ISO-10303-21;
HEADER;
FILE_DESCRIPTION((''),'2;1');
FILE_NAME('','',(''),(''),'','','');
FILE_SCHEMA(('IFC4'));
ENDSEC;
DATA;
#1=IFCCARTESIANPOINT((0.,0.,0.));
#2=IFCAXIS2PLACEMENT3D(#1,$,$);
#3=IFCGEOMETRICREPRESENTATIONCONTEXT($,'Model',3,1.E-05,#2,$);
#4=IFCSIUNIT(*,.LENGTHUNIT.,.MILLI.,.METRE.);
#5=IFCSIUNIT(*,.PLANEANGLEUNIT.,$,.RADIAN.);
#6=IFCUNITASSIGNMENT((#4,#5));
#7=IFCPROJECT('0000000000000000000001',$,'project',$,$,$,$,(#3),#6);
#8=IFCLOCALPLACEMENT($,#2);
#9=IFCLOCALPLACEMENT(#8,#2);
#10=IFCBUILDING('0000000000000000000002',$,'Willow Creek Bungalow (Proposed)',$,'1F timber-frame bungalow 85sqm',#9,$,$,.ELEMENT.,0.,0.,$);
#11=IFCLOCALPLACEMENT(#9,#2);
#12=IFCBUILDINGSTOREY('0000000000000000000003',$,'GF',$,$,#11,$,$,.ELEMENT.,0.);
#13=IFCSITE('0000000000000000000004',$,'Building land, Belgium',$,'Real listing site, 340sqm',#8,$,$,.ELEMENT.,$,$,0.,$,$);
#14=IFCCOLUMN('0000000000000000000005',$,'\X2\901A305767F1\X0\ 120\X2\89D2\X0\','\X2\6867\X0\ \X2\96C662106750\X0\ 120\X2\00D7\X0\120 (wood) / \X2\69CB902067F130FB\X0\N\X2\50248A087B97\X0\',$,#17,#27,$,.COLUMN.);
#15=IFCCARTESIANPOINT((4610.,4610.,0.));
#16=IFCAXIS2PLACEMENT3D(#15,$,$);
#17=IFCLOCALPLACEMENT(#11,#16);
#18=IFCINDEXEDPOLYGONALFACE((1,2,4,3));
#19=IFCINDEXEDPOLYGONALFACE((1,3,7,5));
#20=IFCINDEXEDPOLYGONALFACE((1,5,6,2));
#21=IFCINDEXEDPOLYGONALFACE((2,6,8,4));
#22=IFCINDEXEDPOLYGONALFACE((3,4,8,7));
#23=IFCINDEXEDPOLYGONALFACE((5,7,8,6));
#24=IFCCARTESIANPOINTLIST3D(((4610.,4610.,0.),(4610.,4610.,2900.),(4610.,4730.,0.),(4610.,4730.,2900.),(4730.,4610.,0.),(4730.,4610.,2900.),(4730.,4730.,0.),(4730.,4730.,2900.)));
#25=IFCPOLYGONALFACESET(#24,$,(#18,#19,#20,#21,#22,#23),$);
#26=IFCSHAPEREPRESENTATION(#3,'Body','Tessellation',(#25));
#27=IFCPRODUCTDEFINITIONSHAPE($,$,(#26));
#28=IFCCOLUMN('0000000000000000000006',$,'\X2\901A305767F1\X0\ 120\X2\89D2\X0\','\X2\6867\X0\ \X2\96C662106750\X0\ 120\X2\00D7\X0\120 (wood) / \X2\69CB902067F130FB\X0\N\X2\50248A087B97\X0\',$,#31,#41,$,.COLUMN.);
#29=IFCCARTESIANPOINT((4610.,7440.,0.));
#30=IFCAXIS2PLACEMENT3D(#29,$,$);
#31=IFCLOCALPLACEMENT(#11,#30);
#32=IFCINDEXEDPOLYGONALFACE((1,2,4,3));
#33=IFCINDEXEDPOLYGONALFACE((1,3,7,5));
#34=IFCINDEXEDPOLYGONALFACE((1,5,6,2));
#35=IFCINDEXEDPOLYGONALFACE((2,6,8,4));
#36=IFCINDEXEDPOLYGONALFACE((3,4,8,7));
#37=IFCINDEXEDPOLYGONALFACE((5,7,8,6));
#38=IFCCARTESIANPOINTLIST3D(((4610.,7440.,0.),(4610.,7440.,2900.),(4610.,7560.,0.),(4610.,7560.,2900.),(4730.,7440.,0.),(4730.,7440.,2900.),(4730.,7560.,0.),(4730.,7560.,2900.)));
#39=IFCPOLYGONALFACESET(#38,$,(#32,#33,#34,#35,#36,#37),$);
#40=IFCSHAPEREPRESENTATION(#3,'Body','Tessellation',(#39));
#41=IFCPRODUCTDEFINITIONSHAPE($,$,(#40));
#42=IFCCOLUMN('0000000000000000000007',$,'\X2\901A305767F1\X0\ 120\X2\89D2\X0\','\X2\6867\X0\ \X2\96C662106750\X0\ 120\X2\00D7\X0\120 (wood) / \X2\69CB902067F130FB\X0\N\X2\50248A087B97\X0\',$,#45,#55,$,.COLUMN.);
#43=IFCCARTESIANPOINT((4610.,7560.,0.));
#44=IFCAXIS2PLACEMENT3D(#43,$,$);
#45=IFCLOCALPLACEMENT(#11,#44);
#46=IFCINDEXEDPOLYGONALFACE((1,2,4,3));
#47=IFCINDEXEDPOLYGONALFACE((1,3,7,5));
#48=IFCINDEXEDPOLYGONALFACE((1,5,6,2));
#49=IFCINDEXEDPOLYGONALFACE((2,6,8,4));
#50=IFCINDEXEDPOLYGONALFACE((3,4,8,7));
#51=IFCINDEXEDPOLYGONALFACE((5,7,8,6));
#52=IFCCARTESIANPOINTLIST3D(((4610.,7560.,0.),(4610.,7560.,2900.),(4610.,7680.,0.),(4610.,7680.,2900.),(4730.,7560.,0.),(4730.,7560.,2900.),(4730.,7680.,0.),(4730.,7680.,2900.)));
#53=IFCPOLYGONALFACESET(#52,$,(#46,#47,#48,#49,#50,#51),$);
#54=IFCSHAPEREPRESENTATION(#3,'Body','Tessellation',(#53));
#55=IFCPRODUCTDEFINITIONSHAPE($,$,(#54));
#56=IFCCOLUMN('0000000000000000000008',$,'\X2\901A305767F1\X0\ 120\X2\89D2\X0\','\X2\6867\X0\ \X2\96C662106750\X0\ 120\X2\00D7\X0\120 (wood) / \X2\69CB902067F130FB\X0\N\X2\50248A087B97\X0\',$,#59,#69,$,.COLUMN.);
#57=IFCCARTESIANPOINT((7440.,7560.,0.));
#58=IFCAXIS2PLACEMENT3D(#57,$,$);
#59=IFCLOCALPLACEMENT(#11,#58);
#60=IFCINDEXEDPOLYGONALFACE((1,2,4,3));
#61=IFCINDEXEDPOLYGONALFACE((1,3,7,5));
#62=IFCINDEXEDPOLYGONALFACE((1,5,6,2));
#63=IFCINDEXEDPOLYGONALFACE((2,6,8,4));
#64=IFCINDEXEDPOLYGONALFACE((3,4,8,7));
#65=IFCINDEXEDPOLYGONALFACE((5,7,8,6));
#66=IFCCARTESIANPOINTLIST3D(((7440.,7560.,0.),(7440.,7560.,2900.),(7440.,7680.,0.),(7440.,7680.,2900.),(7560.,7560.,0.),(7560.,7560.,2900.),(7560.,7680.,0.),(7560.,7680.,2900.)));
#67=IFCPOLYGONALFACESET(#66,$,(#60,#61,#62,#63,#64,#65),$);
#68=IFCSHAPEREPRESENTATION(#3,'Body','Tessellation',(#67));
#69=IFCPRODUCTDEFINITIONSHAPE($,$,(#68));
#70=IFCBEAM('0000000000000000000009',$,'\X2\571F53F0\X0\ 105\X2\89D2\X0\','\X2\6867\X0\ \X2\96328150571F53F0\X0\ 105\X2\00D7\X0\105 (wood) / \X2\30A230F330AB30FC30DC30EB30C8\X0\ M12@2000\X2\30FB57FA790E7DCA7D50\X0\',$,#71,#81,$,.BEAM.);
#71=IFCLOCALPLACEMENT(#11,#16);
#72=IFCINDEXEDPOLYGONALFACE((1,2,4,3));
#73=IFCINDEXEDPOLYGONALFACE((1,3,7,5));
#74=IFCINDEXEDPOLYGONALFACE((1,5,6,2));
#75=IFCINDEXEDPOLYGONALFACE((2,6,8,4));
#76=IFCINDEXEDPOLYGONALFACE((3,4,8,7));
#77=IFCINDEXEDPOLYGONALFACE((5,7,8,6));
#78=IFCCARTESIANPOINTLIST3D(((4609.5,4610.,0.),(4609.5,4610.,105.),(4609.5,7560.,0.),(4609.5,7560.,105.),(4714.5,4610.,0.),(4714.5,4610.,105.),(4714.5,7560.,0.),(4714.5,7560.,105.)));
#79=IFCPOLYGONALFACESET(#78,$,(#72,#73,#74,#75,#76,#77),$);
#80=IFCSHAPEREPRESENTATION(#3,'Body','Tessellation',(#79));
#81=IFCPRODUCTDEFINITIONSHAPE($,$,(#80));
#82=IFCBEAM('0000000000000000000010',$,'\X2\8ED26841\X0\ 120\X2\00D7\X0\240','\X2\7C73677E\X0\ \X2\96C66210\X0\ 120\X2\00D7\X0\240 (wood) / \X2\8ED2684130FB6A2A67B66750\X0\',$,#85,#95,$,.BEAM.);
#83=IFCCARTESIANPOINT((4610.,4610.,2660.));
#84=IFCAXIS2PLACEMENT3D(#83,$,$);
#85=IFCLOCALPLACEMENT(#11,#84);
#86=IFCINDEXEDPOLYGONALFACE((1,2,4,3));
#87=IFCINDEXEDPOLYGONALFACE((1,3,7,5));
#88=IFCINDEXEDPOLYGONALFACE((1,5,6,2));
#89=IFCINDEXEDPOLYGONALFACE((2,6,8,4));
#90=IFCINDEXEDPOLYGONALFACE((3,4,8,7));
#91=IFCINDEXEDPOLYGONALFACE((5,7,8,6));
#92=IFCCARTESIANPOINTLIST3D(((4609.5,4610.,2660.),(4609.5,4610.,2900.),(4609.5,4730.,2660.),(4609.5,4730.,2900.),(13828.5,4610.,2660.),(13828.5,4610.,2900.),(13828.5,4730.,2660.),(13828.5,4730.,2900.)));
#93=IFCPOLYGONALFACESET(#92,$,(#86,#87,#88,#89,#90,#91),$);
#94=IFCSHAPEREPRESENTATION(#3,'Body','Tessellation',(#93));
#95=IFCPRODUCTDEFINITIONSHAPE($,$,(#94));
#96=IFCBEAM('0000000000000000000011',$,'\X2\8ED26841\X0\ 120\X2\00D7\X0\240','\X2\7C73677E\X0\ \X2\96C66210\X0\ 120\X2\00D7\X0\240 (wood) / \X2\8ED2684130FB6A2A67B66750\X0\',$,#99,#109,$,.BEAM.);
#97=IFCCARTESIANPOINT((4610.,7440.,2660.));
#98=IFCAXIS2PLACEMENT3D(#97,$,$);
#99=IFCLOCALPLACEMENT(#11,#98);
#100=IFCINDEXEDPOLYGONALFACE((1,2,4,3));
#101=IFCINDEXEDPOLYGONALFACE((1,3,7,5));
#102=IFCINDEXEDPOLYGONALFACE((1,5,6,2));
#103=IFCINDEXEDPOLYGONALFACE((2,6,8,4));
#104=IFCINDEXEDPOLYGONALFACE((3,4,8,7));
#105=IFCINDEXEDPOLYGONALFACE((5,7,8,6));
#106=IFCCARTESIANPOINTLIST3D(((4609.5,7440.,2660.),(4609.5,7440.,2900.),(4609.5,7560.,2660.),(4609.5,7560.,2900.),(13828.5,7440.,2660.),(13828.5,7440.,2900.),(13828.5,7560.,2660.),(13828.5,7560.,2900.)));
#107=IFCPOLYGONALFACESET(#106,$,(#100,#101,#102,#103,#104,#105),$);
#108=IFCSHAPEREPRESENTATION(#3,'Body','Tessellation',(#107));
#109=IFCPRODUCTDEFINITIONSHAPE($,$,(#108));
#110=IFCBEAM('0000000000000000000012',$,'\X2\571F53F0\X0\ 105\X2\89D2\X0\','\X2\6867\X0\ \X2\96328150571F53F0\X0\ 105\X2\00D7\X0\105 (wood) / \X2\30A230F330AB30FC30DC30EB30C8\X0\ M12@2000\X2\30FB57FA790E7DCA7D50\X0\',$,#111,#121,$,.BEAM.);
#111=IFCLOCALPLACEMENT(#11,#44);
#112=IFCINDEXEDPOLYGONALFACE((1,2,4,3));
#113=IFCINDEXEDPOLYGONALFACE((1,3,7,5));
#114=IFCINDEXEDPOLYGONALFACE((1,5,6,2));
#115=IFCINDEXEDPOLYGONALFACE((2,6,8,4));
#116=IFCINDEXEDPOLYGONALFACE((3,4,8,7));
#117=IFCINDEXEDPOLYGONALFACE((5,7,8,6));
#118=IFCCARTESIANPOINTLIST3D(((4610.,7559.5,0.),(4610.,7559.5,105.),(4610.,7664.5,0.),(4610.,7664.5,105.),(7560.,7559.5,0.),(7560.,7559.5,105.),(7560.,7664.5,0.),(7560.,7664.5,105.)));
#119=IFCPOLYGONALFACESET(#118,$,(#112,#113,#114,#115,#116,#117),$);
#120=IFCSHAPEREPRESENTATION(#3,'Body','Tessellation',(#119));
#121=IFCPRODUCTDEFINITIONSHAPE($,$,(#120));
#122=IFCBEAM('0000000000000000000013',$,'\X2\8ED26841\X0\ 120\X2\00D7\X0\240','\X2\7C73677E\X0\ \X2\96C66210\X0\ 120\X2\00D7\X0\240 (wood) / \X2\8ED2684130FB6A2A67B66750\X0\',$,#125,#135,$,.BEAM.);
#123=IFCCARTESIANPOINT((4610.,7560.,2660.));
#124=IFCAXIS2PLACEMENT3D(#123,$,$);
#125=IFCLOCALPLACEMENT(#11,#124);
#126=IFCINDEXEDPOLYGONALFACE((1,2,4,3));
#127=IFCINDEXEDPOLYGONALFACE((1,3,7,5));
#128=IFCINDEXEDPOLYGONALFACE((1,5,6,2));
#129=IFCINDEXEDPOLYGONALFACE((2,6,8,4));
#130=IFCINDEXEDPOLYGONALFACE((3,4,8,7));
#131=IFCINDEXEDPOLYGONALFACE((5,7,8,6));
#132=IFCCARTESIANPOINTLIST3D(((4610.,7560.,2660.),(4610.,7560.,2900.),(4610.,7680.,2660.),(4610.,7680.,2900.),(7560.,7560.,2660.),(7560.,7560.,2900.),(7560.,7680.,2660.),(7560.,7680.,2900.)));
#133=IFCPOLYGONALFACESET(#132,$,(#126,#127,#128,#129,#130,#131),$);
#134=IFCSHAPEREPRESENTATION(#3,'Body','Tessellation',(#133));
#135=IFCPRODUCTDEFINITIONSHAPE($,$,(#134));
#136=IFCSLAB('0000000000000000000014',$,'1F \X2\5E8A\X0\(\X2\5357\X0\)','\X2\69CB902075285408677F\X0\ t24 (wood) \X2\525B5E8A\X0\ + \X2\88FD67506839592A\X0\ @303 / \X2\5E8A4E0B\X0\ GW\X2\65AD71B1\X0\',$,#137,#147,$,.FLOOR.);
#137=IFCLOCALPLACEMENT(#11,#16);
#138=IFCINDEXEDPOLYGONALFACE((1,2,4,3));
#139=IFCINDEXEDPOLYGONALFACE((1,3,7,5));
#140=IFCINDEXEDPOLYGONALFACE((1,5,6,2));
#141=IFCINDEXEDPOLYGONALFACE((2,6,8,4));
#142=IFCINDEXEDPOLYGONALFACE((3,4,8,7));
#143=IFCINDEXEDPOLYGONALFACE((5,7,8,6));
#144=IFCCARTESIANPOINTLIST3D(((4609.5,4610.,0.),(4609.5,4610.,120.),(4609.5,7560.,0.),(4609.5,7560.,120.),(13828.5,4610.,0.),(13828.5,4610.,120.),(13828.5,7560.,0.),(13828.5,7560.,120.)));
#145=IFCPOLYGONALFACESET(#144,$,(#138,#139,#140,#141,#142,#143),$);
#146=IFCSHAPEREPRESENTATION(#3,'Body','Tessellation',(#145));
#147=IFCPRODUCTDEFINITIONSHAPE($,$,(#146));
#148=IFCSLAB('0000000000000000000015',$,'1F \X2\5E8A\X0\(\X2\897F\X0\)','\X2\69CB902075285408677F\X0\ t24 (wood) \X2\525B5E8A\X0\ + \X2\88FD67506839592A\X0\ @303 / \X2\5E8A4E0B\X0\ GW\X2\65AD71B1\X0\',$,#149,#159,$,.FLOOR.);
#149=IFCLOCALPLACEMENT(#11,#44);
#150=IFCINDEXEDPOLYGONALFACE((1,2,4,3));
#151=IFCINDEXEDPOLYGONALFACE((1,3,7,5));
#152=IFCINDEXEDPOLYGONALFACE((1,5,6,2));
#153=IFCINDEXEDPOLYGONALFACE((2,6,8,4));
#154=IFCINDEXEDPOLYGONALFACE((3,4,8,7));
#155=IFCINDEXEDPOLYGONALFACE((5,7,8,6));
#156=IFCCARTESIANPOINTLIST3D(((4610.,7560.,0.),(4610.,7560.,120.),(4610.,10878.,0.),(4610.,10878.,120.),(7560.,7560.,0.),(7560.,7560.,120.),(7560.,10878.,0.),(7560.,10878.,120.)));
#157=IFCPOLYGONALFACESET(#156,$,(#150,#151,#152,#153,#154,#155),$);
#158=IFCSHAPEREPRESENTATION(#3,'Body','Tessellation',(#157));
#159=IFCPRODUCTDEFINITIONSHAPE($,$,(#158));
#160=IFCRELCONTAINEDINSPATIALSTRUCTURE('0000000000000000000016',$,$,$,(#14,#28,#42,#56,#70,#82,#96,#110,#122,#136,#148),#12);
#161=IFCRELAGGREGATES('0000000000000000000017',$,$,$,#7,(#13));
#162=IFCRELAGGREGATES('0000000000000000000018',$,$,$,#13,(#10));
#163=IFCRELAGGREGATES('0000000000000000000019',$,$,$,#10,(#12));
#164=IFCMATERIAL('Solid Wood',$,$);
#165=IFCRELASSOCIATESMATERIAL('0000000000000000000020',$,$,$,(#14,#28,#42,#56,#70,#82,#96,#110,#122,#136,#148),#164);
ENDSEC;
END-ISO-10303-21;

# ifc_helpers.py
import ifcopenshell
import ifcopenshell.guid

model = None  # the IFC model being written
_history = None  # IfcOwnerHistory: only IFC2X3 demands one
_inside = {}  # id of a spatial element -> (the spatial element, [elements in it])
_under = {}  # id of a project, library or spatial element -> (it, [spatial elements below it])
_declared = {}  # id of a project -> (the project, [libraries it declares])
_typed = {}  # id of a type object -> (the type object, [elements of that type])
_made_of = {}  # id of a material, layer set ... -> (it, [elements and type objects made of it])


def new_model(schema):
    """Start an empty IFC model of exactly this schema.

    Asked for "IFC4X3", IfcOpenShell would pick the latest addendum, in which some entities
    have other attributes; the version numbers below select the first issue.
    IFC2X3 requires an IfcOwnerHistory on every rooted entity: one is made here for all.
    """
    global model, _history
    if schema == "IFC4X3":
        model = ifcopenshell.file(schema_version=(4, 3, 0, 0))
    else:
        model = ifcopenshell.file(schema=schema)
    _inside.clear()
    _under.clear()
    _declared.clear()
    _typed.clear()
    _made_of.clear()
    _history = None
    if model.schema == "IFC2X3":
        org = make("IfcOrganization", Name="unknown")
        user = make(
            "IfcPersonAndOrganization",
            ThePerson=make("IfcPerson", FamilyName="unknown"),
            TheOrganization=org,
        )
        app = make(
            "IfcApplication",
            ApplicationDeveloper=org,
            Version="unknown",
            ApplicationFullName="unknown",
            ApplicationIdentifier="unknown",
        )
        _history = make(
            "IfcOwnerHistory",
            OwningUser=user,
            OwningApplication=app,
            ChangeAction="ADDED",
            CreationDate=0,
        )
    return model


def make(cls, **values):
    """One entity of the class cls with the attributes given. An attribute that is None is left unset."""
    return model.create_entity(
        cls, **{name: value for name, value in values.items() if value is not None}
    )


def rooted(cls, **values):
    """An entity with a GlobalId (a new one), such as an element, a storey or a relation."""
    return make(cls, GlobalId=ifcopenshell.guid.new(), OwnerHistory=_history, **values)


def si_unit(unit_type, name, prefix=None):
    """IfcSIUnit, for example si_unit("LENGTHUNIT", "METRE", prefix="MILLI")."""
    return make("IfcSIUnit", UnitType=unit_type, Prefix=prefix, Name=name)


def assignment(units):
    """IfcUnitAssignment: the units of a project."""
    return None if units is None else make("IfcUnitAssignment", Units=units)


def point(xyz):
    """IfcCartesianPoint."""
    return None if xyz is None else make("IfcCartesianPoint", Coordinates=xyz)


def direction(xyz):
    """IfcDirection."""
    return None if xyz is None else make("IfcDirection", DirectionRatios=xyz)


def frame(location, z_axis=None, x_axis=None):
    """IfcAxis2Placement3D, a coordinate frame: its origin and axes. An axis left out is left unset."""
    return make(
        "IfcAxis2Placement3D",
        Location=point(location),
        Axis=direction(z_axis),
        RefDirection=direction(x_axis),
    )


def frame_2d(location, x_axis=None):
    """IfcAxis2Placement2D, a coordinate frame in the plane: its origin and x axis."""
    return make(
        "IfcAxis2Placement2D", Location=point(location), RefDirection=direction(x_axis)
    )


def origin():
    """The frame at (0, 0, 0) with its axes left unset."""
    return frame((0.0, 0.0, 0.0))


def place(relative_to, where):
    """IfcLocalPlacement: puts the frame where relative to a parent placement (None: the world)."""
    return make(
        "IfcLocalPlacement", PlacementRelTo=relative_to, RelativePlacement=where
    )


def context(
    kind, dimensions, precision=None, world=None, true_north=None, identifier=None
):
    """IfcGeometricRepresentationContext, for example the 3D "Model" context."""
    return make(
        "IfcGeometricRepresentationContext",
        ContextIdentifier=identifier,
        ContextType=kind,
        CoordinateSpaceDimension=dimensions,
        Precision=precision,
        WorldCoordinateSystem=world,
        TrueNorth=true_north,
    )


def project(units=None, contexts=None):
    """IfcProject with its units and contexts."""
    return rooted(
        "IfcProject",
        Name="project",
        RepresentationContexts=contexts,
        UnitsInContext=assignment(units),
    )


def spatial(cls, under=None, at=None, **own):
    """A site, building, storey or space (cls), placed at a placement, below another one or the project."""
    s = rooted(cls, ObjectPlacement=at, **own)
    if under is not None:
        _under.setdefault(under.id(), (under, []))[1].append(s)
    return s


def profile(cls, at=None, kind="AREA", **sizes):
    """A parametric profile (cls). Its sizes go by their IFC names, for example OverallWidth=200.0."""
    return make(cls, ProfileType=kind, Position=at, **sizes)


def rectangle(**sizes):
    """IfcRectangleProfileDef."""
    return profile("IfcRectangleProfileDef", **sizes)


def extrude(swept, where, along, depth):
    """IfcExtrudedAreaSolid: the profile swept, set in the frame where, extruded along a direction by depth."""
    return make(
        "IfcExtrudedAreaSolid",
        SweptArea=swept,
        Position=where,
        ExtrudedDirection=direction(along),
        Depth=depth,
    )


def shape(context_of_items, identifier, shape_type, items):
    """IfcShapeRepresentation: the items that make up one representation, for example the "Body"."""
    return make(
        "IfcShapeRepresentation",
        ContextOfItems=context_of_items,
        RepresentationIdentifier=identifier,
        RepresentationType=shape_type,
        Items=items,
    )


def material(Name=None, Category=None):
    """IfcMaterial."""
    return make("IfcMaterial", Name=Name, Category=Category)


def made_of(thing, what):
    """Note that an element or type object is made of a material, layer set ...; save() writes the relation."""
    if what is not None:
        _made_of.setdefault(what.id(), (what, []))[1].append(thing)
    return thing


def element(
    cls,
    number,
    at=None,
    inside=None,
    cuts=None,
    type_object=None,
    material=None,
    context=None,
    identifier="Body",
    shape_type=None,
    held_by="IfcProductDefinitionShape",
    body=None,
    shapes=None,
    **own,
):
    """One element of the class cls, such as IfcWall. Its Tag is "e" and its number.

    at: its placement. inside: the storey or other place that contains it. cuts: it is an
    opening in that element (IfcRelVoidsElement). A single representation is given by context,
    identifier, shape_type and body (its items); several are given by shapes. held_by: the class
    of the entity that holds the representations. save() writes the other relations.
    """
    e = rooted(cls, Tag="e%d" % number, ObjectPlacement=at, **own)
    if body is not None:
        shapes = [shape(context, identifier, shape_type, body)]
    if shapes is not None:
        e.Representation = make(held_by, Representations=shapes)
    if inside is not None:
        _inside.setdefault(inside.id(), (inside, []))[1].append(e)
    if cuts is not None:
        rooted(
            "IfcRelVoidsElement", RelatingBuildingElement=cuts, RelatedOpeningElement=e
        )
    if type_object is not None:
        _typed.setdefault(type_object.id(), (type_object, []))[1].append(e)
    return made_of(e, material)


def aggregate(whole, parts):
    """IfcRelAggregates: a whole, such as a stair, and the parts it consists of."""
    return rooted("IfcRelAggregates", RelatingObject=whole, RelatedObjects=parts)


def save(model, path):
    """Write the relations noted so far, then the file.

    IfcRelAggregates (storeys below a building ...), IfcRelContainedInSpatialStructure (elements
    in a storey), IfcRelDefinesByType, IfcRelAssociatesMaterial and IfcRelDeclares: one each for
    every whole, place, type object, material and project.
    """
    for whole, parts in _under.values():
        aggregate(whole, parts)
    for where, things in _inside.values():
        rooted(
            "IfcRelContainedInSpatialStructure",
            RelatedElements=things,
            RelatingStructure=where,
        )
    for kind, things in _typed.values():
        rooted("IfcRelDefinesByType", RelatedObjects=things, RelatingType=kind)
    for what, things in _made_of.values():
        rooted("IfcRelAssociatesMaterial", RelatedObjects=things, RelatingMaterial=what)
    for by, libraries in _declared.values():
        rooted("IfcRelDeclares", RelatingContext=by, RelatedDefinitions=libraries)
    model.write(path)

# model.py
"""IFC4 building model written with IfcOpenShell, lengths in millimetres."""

from ifc_helpers import new_model, si_unit, frame, frame_2d, origin, place, context, project, spatial, rectangle, extrude, material, element, save


model = new_model("IFC4")

# Units and contexts
model_context = context("Model", 3, precision=1e-05, world=origin())
ifc_project = project(units=[si_unit("LENGTHUNIT", "METRE", prefix="MILLI"), si_unit("PLANEANGLEUNIT", "RADIAN")], contexts=[model_context])

# Site, building, storey
site_placement = place(None, origin())
site = spatial("IfcSite", under=ifc_project, at=site_placement, Name="Building land, Belgium", ObjectType="Real listing site, 340sqm", CompositionType="ELEMENT", RefElevation=0.0)
building_placement = place(site_placement, origin())
building = spatial("IfcBuilding", under=site, at=building_placement, Name="Willow Creek Bungalow (Proposed)", ObjectType="1F timber-frame bungalow 85sqm", CompositionType="ELEMENT", ElevationOfRefHeight=0.0, ElevationOfTerrain=0.0)
storey_placement = place(building_placement, origin())
storey = spatial("IfcBuildingStorey", under=building, at=storey_placement, Name="GF", CompositionType="ELEMENT", Elevation=0.0)

# Columns
ifc_material_1 = material(Name="Solid Wood")
column_1_placement = place(storey_placement, frame((4610.0, 4610.0, 0.0)))
element("IfcColumn", 1, at=column_1_placement, inside=storey, material=ifc_material_1, Name="通し柱 120角", Description="桧 集成材 120×120 (wood) / 構造柱・N値計算", PredefinedType="COLUMN", context=model_context, shape_type="SweptSolid", body=[
    extrude(rectangle(XDim=120.0, YDim=120.0, at=frame_2d((60.0, 60.0))), frame((4610.0, 4610.0, 0.0)), (0.0, 0.0, 1.0), 2900.0),
])
column_2_placement = place(storey_placement, frame((4610.0, 7440.0, 0.0)))
element("IfcColumn", 2, at=column_2_placement, inside=storey, material=ifc_material_1, Name="通し柱 120角", Description="桧 集成材 120×120 (wood) / 構造柱・N値計算", PredefinedType="COLUMN", context=model_context, shape_type="SweptSolid", body=[
    extrude(rectangle(XDim=120.0, YDim=120.0, at=frame_2d((60.0, 60.0))), frame((4610.0, 7440.0, 0.0)), (0.0, 0.0, 1.0), 2900.0),
])
column_3_placement = place(storey_placement, frame((4610.0, 7560.0, 0.0)))
element("IfcColumn", 3, at=column_3_placement, inside=storey, material=ifc_material_1, Name="通し柱 120角", Description="桧 集成材 120×120 (wood) / 構造柱・N値計算", PredefinedType="COLUMN", context=model_context, shape_type="SweptSolid", body=[
    extrude(rectangle(XDim=120.0, YDim=120.0, at=frame_2d((60.0, 60.0))), frame((4610.0, 7560.0, 0.0)), (0.0, 0.0, 1.0), 2900.0),
])
column_4_placement = place(storey_placement, frame((7440.0, 7560.0, 0.0)))
element("IfcColumn", 4, at=column_4_placement, inside=storey, material=ifc_material_1, Name="通し柱 120角", Description="桧 集成材 120×120 (wood) / 構造柱・N値計算", PredefinedType="COLUMN", context=model_context, shape_type="SweptSolid", body=[
    extrude(rectangle(XDim=120.0, YDim=120.0, at=frame_2d((60.0, 60.0))), frame((7440.0, 7560.0, 0.0)), (0.0, 0.0, 1.0), 2900.0),
])

# Beams
beam_1_placement = place(storey_placement, frame((4610.0, 4610.0, 0.0)))
element("IfcBeam", 5, at=beam_1_placement, inside=storey, material=ifc_material_1, Name="土台 105角", Description="桧 防腐土台 105×105 (wood) / アンカーボルト M12@2000・基礎緊結", PredefinedType="BEAM", context=model_context, shape_type="SweptSolid", body=[
    extrude(rectangle(XDim=105.0, YDim=2950.0, at=frame_2d((52.0, 1475.0))), frame((4610.0, 4610.0, 0.0)), (0.0, 0.0, 1.0), 105.0),
])
beam_2_placement = place(storey_placement, frame((4610.0, 4610.0, 2660.0)))
element("IfcBeam", 6, at=beam_2_placement, inside=storey, material=ifc_material_1, Name="軒桁 120×240", Description="米松 集成 120×240 (wood) / 軒桁・横架材", PredefinedType="BEAM", context=model_context, shape_type="SweptSolid", body=[
    extrude(rectangle(XDim=9219.0, YDim=120.0, at=frame_2d((4609.0, 60.0))), frame((4610.0, 4610.0, 2660.0)), (0.0, 0.0, 1.0), 240.0),
])
beam_3_placement = place(storey_placement, frame((4610.0, 7440.0, 2660.0)))
element("IfcBeam", 7, at=beam_3_placement, inside=storey, material=ifc_material_1, Name="軒桁 120×240", Description="米松 集成 120×240 (wood) / 軒桁・横架材", PredefinedType="BEAM", context=model_context, shape_type="SweptSolid", body=[
    extrude(rectangle(XDim=9219.0, YDim=120.0, at=frame_2d((4609.0, 60.0))), frame((4610.0, 7440.0, 2660.0)), (0.0, 0.0, 1.0), 240.0),
])
beam_4_placement = place(storey_placement, frame((4610.0, 7560.0, 0.0)))
element("IfcBeam", 8, at=beam_4_placement, inside=storey, material=ifc_material_1, Name="土台 105角", Description="桧 防腐土台 105×105 (wood) / アンカーボルト M12@2000・基礎緊結", PredefinedType="BEAM", context=model_context, shape_type="SweptSolid", body=[
    extrude(rectangle(XDim=2950.0, YDim=105.0, at=frame_2d((1475.0, 52.0))), frame((4610.0, 7560.0, 0.0)), (0.0, 0.0, 1.0), 105.0),
])
beam_5_placement = place(storey_placement, frame((4610.0, 7560.0, 2660.0)))
element("IfcBeam", 9, at=beam_5_placement, inside=storey, material=ifc_material_1, Name="軒桁 120×240", Description="米松 集成 120×240 (wood) / 軒桁・横架材", PredefinedType="BEAM", context=model_context, shape_type="SweptSolid", body=[
    extrude(rectangle(XDim=2950.0, YDim=120.0, at=frame_2d((1475.0, 60.0))), frame((4610.0, 7560.0, 2660.0)), (0.0, 0.0, 1.0), 240.0),
])

# Slabs
slab_1_placement = place(storey_placement, frame((4610.0, 4610.0, 0.0)))
element("IfcSlab", 10, at=slab_1_placement, inside=storey, material=ifc_material_1, Name="1F 床(南)", Description="構造用合板 t24 (wood) 剛床 + 製材根太 @303 / 床下 GW断熱", PredefinedType="FLOOR", context=model_context, shape_type="SweptSolid", body=[
    extrude(rectangle(XDim=9219.0, YDim=2950.0, at=frame_2d((4609.0, 1475.0))), frame((4610.0, 4610.0, 0.0)), (0.0, 0.0, 1.0), 120.0),
])
slab_2_placement = place(storey_placement, frame((4610.0, 7560.0, 0.0)))
element("IfcSlab", 11, at=slab_2_placement, inside=storey, material=ifc_material_1, Name="1F 床(西)", Description="構造用合板 t24 (wood) 剛床 + 製材根太 @303 / 床下 GW断熱", PredefinedType="FLOOR", context=model_context, shape_type="SweptSolid", body=[
    extrude(rectangle(XDim=2950.0, YDim=3318.0, at=frame_2d((1475.0, 1659.0))), frame((4610.0, 7560.0, 0.0)), (0.0, 0.0, 1.0), 120.0),
])

save(model, "model.ifc")
